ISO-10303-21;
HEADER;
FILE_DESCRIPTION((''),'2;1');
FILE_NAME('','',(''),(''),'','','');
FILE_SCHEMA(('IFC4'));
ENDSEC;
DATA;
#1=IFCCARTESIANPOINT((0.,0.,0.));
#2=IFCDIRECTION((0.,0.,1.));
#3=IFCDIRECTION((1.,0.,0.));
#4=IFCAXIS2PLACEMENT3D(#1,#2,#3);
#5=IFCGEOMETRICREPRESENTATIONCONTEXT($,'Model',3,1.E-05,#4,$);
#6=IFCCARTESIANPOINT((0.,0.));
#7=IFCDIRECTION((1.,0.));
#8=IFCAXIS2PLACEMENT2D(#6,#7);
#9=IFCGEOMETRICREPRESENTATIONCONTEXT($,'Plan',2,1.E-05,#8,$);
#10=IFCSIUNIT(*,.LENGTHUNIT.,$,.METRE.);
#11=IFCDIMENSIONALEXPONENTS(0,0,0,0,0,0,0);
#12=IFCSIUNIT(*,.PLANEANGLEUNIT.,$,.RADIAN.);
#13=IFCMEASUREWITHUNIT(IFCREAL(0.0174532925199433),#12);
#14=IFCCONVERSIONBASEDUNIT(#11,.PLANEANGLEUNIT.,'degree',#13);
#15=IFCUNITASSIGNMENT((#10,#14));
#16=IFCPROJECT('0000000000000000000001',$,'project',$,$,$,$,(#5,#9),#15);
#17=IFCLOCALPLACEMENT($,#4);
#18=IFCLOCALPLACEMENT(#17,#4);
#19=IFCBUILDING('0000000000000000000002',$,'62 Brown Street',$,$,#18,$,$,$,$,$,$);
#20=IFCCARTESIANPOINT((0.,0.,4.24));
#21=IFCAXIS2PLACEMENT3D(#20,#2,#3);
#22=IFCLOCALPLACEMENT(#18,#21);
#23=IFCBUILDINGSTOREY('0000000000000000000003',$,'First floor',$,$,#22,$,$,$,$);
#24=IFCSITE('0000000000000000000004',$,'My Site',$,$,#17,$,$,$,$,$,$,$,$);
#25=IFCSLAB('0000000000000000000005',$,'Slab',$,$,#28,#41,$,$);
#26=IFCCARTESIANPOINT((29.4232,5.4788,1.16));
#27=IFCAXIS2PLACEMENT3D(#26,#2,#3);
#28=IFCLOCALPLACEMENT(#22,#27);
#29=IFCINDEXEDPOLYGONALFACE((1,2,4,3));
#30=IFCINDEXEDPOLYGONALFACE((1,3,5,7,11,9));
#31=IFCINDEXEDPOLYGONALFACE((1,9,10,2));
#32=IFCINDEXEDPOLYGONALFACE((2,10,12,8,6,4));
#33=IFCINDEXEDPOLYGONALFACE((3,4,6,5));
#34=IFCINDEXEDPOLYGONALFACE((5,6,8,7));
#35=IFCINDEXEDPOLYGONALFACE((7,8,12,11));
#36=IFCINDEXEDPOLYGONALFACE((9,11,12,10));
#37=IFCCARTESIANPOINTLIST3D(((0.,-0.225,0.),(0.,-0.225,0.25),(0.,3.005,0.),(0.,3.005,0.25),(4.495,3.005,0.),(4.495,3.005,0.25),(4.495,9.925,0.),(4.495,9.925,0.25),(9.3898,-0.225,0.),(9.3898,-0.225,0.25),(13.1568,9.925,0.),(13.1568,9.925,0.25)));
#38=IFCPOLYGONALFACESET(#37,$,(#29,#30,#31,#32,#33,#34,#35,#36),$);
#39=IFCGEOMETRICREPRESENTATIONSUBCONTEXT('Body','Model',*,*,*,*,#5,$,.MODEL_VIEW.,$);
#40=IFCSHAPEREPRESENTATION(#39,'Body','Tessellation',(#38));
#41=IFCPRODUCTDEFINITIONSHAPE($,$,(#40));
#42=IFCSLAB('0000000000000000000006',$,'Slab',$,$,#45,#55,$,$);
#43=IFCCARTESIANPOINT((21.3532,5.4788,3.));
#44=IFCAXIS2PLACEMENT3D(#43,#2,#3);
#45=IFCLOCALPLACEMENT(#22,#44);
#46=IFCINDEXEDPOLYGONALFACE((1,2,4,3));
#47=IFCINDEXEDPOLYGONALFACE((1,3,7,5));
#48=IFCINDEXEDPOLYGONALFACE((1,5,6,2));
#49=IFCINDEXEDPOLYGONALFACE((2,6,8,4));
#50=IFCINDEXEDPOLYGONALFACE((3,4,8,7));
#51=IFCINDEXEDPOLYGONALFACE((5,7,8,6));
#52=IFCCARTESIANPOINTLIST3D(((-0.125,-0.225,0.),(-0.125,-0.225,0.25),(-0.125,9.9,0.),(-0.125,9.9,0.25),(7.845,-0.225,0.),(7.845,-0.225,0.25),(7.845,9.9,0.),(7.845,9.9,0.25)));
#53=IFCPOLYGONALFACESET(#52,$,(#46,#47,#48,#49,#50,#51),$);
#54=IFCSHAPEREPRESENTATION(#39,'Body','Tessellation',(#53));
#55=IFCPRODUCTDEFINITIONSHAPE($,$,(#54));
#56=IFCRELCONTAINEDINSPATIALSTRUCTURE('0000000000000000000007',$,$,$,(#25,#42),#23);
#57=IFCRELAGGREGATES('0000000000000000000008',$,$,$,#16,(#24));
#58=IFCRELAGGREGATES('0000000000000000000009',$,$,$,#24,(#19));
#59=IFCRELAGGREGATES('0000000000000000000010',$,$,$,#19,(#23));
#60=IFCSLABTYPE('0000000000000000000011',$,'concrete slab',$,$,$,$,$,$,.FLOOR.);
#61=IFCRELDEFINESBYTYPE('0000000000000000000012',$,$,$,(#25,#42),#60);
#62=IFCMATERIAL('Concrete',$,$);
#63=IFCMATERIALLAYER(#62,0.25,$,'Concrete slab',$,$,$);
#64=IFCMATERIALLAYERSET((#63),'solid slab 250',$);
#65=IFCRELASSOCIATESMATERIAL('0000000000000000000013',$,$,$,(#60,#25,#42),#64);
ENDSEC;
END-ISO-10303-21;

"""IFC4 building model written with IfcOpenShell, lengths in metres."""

from ifc_helpers import new_model, entity, si_unit, converted_unit, frame, origin_with_axes, origin_2d_with_axis, place, context, subcontext, project, spatial, line, indexed_curve, outline, extrude, material, layer, layer_set, layer_usage, type_object, element, save


model = new_model("IFC4")

# Units and contexts
model_context = context("Model", 3, precision=1e-05, world=origin_with_axes())
plan_context = context("Plan", 2, precision=1e-05, world=origin_2d_with_axis())
body_context_1 = subcontext(model_context, "Body", "Model", "MODEL_VIEW")
ifc_project = project(units=[si_unit("LENGTHUNIT", "METRE"), converted_unit("PLANEANGLEUNIT", "degree", entity("IfcReal", 0.0174532925199433), si_unit("PLANEANGLEUNIT", "RADIAN"), dimensions=[0, 0, 0, 0, 0, 0, 0])], contexts=[model_context, plan_context])

# Site, building, storey
site_placement = place(None, origin_with_axes())
site = spatial("IfcSite", under=ifc_project, at=site_placement, Name="My Site")
building_placement = place(site_placement, origin_with_axes())
building = spatial("IfcBuilding", under=site, at=building_placement, Name="62 Brown Street")
storey_placement = place(building_placement, frame((0.0, 0.0, 4.24), z_axis=(0.0, 0.0, 1.0), x_axis=(1.0, 0.0, 0.0)))
storey = spatial("IfcBuildingStorey", under=building, at=storey_placement, Name="First floor")

# Slabs
ifc_material_1 = material(Name="Concrete")
ifc_layer_1 = layer(ifc_material_1, 0.25, Name="Concrete slab")
ifc_layer_set_1 = layer_set([ifc_layer_1], Name="solid slab 250")
slab_type = type_object("IfcSlabType", Name="concrete slab", PredefinedType="FLOOR", material=ifc_layer_set_1)
ifc_layer_usage_1 = layer_usage(ifc_layer_set_1, "AXIS3", "POSITIVE", 0.0)
slab_1_placement = place(storey_placement, frame((29.4232, 5.4788, 1.16), z_axis=(0.0, 0.0, 1.0), x_axis=(1.0, 0.0, 0.0)))
element("IfcSlab", 1, at=slab_1_placement, inside=storey, type_object=slab_type, material=ifc_layer_usage_1, Name="Slab", context=body_context_1, shape_type="SweptSolid", body=[
    extrude(outline(indexed_curve([(0.0, 3.005), (0.0, -0.225), (9.3898, -0.225), (13.1568, 9.925), (4.495, 9.925), (4.495, 3.005)], segments=[line(4, 3), line(3, 2), line(2, 1), line(1, 6), line(6, 5), line(5, 4)], self_intersect=False)), None, (0.0, 0.0, 1.0), 0.25),
])
ifc_layer_usage_2 = layer_usage(ifc_layer_set_1, "AXIS3", "POSITIVE", 0.0)
slab_2_placement = place(storey_placement, frame((21.3532, 5.4788, 3.0), z_axis=(0.0, 0.0, 1.0), x_axis=(1.0, 0.0, 0.0)))
element("IfcSlab", 2, at=slab_2_placement, inside=storey, type_object=slab_type, material=ifc_layer_usage_2, Name="Slab", context=body_context_1, shape_type="SweptSolid", body=[
    extrude(outline(indexed_curve([(7.845, -0.225), (-0.125, -0.225), (-0.125, 9.9), (7.845, 9.9)], segments=[line(4, 1), line(1, 2), line(2, 3), line(3, 4)], self_intersect=False)), None, (0.0, 0.0, 1.0), 0.25),
])

save(model, "model.ifc")
